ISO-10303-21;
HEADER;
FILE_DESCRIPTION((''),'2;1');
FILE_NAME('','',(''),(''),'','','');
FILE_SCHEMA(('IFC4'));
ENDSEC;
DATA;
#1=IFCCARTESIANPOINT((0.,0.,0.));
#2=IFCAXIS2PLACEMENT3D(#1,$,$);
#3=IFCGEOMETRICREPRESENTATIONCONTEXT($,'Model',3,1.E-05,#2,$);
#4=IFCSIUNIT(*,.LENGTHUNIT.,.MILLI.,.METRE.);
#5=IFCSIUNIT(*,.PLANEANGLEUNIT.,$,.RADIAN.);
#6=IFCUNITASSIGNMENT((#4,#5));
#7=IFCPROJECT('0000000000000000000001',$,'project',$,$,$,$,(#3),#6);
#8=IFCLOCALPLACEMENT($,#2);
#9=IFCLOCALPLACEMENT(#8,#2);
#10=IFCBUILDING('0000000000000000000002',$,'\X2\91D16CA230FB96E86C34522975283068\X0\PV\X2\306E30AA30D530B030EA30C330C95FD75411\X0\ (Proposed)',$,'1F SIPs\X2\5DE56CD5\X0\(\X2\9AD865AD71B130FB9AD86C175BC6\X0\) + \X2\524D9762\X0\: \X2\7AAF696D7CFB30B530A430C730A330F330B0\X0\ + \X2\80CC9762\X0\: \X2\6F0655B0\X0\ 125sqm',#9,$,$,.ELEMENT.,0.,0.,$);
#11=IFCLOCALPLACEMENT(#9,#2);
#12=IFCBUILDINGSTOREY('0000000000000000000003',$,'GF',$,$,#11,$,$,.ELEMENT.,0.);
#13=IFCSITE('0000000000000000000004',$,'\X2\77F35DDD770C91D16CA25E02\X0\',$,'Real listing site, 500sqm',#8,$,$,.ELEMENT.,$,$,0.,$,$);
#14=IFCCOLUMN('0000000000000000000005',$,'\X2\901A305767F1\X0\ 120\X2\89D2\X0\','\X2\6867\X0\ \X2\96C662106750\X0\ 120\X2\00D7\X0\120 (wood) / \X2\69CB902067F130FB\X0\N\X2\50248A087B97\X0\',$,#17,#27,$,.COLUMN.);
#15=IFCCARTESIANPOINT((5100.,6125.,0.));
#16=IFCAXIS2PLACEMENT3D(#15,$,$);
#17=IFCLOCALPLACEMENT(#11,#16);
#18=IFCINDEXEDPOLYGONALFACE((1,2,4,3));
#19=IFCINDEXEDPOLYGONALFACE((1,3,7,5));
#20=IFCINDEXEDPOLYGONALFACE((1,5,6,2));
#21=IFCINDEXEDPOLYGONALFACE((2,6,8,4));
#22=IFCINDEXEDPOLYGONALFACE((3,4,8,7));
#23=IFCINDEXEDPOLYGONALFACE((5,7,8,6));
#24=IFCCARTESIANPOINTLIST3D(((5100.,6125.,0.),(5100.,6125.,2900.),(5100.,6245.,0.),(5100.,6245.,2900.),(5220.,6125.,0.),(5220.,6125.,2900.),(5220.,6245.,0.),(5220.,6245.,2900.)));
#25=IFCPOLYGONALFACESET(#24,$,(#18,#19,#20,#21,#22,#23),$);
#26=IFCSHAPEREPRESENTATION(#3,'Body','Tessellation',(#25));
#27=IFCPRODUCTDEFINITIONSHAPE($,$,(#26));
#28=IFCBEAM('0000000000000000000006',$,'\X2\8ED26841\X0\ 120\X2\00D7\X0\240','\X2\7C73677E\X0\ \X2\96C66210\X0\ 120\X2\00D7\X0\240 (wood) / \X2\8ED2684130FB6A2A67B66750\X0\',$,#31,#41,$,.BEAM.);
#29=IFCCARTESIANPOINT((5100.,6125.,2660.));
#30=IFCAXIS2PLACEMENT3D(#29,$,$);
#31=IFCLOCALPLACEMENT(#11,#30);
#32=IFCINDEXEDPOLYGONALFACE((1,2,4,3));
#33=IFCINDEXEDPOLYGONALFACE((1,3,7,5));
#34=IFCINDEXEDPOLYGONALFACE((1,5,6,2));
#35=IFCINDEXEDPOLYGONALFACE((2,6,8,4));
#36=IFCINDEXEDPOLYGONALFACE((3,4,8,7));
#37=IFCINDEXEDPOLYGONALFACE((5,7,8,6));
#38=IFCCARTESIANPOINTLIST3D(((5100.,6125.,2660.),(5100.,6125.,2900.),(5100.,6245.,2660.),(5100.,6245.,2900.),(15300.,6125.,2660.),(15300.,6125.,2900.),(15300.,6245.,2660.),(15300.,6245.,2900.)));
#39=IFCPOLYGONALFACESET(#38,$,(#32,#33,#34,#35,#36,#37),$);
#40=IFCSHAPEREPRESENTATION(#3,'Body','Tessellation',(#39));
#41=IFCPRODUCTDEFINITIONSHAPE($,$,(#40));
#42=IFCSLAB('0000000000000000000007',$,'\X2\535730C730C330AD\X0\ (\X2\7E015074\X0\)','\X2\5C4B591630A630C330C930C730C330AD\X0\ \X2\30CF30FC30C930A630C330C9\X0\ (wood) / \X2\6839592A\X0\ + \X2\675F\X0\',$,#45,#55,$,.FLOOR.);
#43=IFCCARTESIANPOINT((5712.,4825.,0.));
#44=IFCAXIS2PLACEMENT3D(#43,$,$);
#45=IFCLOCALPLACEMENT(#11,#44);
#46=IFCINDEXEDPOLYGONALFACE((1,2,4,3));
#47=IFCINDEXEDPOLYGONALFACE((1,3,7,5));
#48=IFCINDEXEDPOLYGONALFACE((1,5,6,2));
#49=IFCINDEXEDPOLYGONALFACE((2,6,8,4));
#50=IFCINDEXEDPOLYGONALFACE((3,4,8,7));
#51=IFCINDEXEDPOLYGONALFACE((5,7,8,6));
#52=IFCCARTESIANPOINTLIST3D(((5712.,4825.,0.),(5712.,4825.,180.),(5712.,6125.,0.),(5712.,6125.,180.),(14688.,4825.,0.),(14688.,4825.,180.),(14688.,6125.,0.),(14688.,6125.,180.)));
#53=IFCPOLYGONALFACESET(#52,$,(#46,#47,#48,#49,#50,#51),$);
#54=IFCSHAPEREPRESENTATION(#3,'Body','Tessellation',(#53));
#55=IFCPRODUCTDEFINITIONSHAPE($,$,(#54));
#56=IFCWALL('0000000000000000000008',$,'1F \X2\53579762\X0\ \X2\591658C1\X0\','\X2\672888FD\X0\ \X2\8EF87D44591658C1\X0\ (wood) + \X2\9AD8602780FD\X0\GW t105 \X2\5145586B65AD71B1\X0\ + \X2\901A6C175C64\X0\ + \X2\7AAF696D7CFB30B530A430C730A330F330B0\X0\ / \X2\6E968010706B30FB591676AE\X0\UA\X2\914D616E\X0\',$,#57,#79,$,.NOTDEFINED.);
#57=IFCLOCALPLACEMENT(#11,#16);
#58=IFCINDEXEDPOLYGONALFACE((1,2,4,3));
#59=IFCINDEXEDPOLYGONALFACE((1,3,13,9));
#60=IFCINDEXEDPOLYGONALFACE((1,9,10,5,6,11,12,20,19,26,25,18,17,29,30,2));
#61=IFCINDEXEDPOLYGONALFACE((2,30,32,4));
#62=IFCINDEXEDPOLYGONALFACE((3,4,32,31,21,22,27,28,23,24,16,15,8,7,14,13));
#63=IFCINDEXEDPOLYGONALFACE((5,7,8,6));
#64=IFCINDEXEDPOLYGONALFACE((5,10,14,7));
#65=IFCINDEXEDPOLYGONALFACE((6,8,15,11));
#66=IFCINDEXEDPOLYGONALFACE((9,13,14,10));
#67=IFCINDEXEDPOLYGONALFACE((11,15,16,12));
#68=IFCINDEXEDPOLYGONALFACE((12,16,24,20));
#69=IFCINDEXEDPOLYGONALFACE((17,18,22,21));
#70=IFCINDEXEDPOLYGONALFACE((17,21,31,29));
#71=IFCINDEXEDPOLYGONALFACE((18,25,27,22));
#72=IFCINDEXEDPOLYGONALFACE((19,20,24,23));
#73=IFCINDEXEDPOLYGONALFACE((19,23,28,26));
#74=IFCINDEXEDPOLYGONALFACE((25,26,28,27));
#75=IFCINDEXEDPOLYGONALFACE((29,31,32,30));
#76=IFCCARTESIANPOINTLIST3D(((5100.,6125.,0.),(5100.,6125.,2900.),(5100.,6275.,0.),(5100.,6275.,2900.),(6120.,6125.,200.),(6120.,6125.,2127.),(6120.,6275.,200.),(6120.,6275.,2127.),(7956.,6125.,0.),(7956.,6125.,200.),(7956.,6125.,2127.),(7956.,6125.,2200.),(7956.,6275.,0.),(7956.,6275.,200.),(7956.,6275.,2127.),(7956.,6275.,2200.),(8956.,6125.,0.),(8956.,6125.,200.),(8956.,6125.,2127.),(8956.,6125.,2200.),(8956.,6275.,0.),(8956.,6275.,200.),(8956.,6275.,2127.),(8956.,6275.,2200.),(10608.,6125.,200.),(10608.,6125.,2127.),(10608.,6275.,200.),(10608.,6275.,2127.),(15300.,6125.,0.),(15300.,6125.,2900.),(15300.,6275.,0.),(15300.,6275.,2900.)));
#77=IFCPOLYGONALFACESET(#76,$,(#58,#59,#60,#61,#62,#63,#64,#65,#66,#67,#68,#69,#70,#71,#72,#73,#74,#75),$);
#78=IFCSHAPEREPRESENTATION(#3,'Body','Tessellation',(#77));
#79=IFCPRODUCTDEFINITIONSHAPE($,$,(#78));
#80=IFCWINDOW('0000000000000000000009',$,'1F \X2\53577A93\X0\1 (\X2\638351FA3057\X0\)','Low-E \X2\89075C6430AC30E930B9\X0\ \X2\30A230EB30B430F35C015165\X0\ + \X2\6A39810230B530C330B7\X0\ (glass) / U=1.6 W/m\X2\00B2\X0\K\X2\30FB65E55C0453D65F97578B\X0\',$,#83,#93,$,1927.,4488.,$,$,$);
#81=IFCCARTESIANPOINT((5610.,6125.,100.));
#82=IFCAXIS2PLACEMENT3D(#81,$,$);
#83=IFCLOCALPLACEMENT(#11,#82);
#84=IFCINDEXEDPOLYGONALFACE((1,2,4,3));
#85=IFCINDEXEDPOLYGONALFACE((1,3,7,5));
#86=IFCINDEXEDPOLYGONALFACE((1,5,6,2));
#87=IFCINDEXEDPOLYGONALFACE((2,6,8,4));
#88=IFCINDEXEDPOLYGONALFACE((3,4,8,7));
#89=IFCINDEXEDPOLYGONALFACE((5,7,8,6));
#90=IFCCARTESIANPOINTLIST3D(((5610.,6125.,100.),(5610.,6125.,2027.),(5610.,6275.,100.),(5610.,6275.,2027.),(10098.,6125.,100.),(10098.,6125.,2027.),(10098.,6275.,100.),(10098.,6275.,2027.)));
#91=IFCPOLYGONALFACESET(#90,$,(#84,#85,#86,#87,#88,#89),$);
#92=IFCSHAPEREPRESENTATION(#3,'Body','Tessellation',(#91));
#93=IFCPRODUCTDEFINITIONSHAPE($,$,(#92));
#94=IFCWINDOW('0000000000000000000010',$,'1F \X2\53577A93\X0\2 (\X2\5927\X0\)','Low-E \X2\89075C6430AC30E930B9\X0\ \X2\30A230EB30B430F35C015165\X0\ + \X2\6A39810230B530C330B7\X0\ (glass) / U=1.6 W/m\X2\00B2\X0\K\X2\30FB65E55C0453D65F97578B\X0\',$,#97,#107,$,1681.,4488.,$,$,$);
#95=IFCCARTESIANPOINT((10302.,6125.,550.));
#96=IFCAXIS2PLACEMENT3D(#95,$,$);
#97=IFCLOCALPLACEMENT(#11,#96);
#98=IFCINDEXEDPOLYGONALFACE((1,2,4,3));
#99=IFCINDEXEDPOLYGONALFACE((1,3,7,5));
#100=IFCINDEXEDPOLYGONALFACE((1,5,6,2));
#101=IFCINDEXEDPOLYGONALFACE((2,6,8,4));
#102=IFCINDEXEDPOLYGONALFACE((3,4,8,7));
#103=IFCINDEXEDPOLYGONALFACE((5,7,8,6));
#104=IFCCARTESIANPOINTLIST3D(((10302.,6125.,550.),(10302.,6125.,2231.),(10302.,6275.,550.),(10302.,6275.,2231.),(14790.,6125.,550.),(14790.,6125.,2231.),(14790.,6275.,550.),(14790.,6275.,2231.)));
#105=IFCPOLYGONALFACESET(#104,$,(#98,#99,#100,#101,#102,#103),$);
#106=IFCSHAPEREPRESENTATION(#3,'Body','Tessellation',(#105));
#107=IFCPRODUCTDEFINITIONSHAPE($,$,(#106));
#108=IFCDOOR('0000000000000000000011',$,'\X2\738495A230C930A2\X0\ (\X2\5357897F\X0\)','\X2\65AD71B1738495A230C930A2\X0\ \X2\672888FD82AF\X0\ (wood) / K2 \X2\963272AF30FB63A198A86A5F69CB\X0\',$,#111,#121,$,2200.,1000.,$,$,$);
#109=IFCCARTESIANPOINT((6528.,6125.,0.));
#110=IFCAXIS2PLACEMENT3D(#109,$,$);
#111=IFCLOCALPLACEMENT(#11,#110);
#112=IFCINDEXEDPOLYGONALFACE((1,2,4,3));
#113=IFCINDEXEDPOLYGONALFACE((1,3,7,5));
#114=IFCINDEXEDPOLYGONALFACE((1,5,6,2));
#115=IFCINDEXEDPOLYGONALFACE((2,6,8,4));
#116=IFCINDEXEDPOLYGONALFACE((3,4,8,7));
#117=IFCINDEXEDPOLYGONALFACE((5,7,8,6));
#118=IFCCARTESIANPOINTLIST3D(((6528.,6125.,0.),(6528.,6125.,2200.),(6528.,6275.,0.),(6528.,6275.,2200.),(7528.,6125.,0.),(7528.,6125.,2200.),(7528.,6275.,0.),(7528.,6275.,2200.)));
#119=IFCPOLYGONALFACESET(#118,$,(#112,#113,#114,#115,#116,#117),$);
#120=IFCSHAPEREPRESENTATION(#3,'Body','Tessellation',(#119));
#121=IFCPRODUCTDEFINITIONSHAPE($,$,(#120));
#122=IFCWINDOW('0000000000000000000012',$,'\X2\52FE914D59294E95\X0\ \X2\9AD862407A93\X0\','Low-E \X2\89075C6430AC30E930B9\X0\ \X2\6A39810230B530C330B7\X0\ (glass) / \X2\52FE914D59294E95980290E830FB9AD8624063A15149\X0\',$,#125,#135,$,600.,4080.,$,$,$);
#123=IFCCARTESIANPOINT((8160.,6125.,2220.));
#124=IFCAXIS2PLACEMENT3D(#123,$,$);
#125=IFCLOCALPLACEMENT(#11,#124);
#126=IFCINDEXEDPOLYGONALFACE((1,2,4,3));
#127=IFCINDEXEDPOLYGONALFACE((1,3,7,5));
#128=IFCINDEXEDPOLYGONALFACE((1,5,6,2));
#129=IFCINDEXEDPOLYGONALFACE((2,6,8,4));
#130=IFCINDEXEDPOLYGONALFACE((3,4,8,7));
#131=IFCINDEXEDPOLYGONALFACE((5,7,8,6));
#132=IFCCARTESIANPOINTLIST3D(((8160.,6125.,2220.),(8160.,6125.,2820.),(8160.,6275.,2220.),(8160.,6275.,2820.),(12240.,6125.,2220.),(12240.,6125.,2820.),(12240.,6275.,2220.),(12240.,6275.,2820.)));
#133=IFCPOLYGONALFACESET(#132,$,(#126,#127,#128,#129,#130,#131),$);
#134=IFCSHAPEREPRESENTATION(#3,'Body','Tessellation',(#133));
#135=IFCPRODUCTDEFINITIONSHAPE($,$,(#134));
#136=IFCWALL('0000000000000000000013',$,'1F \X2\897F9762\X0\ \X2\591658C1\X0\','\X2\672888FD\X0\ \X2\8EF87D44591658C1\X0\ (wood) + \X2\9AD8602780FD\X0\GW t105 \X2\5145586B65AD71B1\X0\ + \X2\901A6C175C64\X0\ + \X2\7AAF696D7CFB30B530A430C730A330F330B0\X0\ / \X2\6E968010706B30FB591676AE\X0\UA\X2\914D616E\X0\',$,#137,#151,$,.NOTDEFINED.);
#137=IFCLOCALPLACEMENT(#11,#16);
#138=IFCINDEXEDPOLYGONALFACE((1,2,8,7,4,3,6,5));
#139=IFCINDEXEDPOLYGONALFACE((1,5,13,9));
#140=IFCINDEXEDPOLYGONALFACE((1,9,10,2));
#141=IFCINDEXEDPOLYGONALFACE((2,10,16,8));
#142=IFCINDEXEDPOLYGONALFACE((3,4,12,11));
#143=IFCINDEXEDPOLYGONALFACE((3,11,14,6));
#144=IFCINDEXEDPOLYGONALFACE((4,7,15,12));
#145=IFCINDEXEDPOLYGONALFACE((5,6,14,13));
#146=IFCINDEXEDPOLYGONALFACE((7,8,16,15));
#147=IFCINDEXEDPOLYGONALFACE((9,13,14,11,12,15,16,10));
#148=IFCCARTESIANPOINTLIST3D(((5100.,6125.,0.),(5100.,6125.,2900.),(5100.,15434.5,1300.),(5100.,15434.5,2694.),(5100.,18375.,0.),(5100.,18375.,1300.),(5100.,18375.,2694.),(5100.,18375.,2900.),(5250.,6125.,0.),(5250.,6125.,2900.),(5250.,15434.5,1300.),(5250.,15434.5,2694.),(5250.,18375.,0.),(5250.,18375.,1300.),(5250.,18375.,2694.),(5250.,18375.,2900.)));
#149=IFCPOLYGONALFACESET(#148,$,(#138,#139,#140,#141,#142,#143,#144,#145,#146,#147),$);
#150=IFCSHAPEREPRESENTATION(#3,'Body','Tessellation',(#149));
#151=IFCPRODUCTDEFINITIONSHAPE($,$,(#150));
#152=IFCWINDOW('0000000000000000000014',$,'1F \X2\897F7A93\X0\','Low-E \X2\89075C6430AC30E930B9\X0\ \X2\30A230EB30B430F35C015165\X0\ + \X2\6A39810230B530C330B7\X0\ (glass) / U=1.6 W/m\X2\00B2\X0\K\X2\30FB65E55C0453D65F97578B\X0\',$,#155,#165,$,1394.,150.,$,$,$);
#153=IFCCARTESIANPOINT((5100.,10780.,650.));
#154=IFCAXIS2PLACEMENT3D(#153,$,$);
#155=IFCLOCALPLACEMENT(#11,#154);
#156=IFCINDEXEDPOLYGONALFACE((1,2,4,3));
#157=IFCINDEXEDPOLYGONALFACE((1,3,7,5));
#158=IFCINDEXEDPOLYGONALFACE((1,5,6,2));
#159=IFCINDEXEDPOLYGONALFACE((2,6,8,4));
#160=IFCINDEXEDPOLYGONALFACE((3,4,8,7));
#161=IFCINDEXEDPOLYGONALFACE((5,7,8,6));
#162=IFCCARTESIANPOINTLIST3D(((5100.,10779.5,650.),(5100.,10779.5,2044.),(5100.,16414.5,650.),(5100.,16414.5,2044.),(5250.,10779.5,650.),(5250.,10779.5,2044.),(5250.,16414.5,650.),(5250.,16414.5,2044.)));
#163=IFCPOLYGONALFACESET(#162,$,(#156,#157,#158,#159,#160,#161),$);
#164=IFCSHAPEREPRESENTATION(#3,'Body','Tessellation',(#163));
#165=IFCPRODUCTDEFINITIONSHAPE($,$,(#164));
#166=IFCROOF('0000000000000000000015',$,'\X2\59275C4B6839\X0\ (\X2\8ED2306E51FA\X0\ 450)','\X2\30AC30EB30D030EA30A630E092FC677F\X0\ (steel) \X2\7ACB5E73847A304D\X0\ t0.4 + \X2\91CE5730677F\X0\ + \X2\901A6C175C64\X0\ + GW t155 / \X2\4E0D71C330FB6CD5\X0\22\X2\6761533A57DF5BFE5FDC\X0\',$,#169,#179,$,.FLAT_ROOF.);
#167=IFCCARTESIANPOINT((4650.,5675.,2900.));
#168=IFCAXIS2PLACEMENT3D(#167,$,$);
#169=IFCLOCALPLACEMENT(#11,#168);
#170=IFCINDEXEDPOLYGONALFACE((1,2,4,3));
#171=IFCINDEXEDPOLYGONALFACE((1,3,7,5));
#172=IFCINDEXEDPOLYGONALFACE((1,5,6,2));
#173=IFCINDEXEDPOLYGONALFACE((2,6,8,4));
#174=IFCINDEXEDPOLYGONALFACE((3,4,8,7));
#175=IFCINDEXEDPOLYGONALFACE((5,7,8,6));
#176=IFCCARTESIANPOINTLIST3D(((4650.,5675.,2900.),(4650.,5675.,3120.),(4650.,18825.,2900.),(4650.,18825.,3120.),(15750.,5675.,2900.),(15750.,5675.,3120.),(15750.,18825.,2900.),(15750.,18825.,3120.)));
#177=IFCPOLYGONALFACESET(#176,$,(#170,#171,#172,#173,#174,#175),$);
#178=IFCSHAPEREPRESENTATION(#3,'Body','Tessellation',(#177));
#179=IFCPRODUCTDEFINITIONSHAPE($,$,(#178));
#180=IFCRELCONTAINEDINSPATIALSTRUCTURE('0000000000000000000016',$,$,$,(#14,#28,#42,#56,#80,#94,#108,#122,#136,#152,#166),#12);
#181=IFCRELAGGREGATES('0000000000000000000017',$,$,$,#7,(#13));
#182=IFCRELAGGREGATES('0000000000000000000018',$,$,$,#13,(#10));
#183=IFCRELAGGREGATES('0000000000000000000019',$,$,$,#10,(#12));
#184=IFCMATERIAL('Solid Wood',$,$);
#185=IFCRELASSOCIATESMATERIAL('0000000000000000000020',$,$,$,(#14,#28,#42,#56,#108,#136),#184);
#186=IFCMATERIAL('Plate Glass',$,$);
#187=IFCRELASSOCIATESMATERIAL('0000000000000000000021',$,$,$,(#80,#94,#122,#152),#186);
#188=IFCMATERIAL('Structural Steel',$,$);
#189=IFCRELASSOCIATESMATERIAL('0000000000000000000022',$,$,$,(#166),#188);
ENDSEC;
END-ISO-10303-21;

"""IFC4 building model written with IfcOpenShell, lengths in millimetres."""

from ifc_helpers import new_model, si_unit, frame, frame_2d, origin, place, context, project, spatial, rectangle, extrude, material, element, fill, save


model = new_model("IFC4")

# Units and contexts
model_context = context("Model", 3, precision=1e-05, world=origin())
ifc_project = project(units=[si_unit("LENGTHUNIT", "METRE", prefix="MILLI"), si_unit("PLANEANGLEUNIT", "RADIAN")], contexts=[model_context])

# Site, building, storey
site_placement = place(None, origin())
site = spatial("IfcSite", under=ifc_project, at=site_placement, Name="石川県金沢市", ObjectType="Real listing site, 500sqm", CompositionType="ELEMENT", RefElevation=0.0)
building_placement = place(site_placement, origin())
building = spatial("IfcBuilding", under=site, at=building_placement, Name="金沢・雨水利用とPVのオフグリッド志向 (Proposed)", ObjectType="1F SIPs工法(高断熱・高気密) + 前面: 窯業系サイディング + 背面: 漆喰 125sqm", CompositionType="ELEMENT", ElevationOfRefHeight=0.0, ElevationOfTerrain=0.0)
storey_placement = place(building_placement, origin())
storey = spatial("IfcBuildingStorey", under=building, at=storey_placement, Name="GF", CompositionType="ELEMENT", Elevation=0.0)

# Column
ifc_material_1 = material(Name="Solid Wood")
column_1_placement = place(storey_placement, frame((5100.0, 6125.0, 0.0)))
element("IfcColumn", 1, at=column_1_placement, inside=storey, material=ifc_material_1, Name="通し柱 120角", Description="桧 集成材 120×120 (wood) / 構造柱・N値計算", PredefinedType="COLUMN", context=model_context, shape_type="SweptSolid", body=[
    extrude(rectangle(XDim=120.0, YDim=120.0, at=frame_2d((60.0, 60.0))), frame((5100.0, 6125.0, 0.0)), (0.0, 0.0, 1.0), 2900.0),
])

# Beam
beam_1_placement = place(storey_placement, frame((5100.0, 6125.0, 2660.0)))
element("IfcBeam", 2, at=beam_1_placement, inside=storey, material=ifc_material_1, Name="軒桁 120×240", Description="米松 集成 120×240 (wood) / 軒桁・横架材", PredefinedType="BEAM", context=model_context, shape_type="SweptSolid", body=[
    extrude(rectangle(XDim=10200.0, YDim=120.0, at=frame_2d((5100.0, 60.0))), frame((5100.0, 6125.0, 2660.0)), (0.0, 0.0, 1.0), 240.0),
])

# Slab
slab_1_placement = place(storey_placement, frame((5712.0, 4825.0, 0.0)))
element("IfcSlab", 3, at=slab_1_placement, inside=storey, material=ifc_material_1, Name="南デッキ (縁側)", Description="屋外ウッドデッキ ハードウッド (wood) / 根太 + 束", PredefinedType="FLOOR", context=model_context, shape_type="SweptSolid", body=[
    extrude(rectangle(XDim=8976.0, YDim=1300.0, at=frame_2d((4488.0, 650.0))), frame((5712.0, 4825.0, 0.0)), (0.0, 0.0, 1.0), 180.0),
])

# Wall, openings, windows, door
wall_1_placement = place(storey_placement, frame((5100.0, 6125.0, 0.0)))
wall_1 = element("IfcWall", 4, at=wall_1_placement, inside=storey, material=ifc_material_1, Name="1F 南面 外壁", Description="木製 軸組外壁 (wood) + 高性能GW t105 充填断熱 + 通気層 + 窯業系サイディング / 準耐火・外皮UA配慮", PredefinedType="NOTDEFINED", context=model_context, shape_type="SweptSolid", body=[
    extrude(rectangle(XDim=10200.0, YDim=150.0, at=frame_2d((5100.0, 75.0))), frame((5100.0, 6125.0, 0.0)), (0.0, 0.0, 1.0), 2900.0),
])
opening_1_placement = place(storey_placement, frame((5610.0, 6125.0, 100.0)))
opening_1 = element("IfcOpeningElement", 5, at=opening_1_placement, cuts=wall_1, PredefinedType="NOTDEFINED", context=model_context, shape_type="SweptSolid", body=[
    extrude(rectangle(XDim=4488.0, YDim=150.0, at=frame_2d((2244.0, 75.0))), frame((5610.0, 6125.0, 100.0)), (0.0, 0.0, 1.0), 1927.0),
])
opening_2_placement = place(storey_placement, frame((10302.0, 6125.0, 550.0)))
opening_2 = element("IfcOpeningElement", 6, at=opening_2_placement, cuts=wall_1, PredefinedType="NOTDEFINED", context=model_context, shape_type="SweptSolid", body=[
    extrude(rectangle(XDim=4488.0, YDim=150.0, at=frame_2d((2244.0, 75.0))), frame((10302.0, 6125.0, 550.0)), (0.0, 0.0, 1.0), 1681.0),
])
opening_3_placement = place(storey_placement, frame((6528.0, 6125.0, 0.0)))
opening_3 = element("IfcOpeningElement", 7, at=opening_3_placement, cuts=wall_1, PredefinedType="NOTDEFINED", context=model_context, shape_type="SweptSolid", body=[
    extrude(rectangle(XDim=1000.0, YDim=150.0, at=frame_2d((500.0, 75.0))), frame((6528.0, 6125.0, 0.0)), (0.0, 0.0, 1.0), 2200.0),
])
opening_4_placement = place(storey_placement, frame((8160.0, 6125.0, 2220.0)))
opening_4 = element("IfcOpeningElement", 8, at=opening_4_placement, cuts=wall_1, PredefinedType="NOTDEFINED", context=model_context, shape_type="SweptSolid", body=[
    extrude(rectangle(XDim=4080.0, YDim=150.0, at=frame_2d((2040.0, 75.0))), frame((8160.0, 6125.0, 2220.0)), (0.0, 0.0, 1.0), 600.0),
])
ifc_material_2 = material(Name="Plate Glass")
window_1_placement = place(storey_placement, frame((5610.0, 6125.0, 100.0)))
window_1 = element("IfcWindow", 9, at=window_1_placement, inside=storey, material=ifc_material_2, Name="1F 南窓1 (掃出し)", Description="Low-E 複層ガラス アルゴン封入 + 樹脂サッシ (glass) / U=1.6 W/m²K・日射取得型", OverallHeight=1927.0, OverallWidth=4488.0, context=model_context, shape_type="SweptSolid", body=[
    extrude(rectangle(XDim=4488.0, YDim=150.0, at=frame_2d((2244.0, 75.0))), frame((5610.0, 6125.0, 100.0)), (0.0, 0.0, 1.0), 1927.0),
])
fill(opening_1, window_1)
window_2_placement = place(storey_placement, frame((10302.0, 6125.0, 550.0)))
window_2 = element("IfcWindow", 10, at=window_2_placement, inside=storey, material=ifc_material_2, Name="1F 南窓2 (大)", Description="Low-E 複層ガラス アルゴン封入 + 樹脂サッシ (glass) / U=1.6 W/m²K・日射取得型", OverallHeight=1681.0, OverallWidth=4488.0, context=model_context, shape_type="SweptSolid", body=[
    extrude(rectangle(XDim=4488.0, YDim=150.0, at=frame_2d((2244.0, 75.0))), frame((10302.0, 6125.0, 550.0)), (0.0, 0.0, 1.0), 1681.0),
])
fill(opening_2, window_2)
door_placement = place(storey_placement, frame((6528.0, 6125.0, 0.0)))
door = element("IfcDoor", 11, at=door_placement, inside=storey, material=ifc_material_1, Name="玄関ドア (南西)", Description="断熱玄関ドア 木製芯 (wood) / K2 防犯・採風機構", OverallHeight=2200.0, OverallWidth=1000.0, context=model_context, shape_type="SweptSolid", body=[
    extrude(rectangle(XDim=1000.0, YDim=150.0, at=frame_2d((500.0, 75.0))), frame((6528.0, 6125.0, 0.0)), (0.0, 0.0, 1.0), 2200.0),
])
fill(opening_3, door)
window_3_placement = place(storey_placement, frame((8160.0, 6125.0, 2220.0)))
window_3 = element("IfcWindow", 12, at=window_3_placement, inside=storey, material=ifc_material_2, Name="勾配天井 高所窓", Description="Low-E 複層ガラス 樹脂サッシ (glass) / 勾配天井頂部・高所採光", OverallHeight=600.0, OverallWidth=4080.0, context=model_context, shape_type="SweptSolid", body=[
    extrude(rectangle(XDim=4080.0, YDim=150.0, at=frame_2d((2040.0, 75.0))), frame((8160.0, 6125.0, 2220.0)), (0.0, 0.0, 1.0), 600.0),
])
fill(opening_4, window_3)

# Wall, opening, window
wall_2_placement = place(storey_placement, frame((5100.0, 6125.0, 0.0)))
wall_2 = element("IfcWall", 13, at=wall_2_placement, inside=storey, material=ifc_material_1, Name="1F 西面 外壁", Description="木製 軸組外壁 (wood) + 高性能GW t105 充填断熱 + 通気層 + 窯業系サイディング / 準耐火・外皮UA配慮", PredefinedType="NOTDEFINED", context=model_context, shape_type="SweptSolid", body=[
    extrude(rectangle(XDim=150.0, YDim=12250.0, at=frame_2d((75.0, 6125.0))), frame((5100.0, 6125.0, 0.0)), (0.0, 0.0, 1.0), 2900.0),
])
opening_5_placement = place(storey_placement, frame((5100.0, 10780.0, 650.0)))
opening_5 = element("IfcOpeningElement", 14, at=opening_5_placement, cuts=wall_2, PredefinedType="NOTDEFINED", context=model_context, shape_type="SweptSolid", body=[
    extrude(rectangle(XDim=150.0, YDim=5635.0, at=frame_2d((75.0, 2817.0))), frame((5100.0, 10780.0, 650.0)), (0.0, 0.0, 1.0), 1394.0),
])
window_4_placement = place(storey_placement, frame((5100.0, 10780.0, 650.0)))
window_4 = element("IfcWindow", 15, at=window_4_placement, inside=storey, material=ifc_material_2, Name="1F 西窓", Description="Low-E 複層ガラス アルゴン封入 + 樹脂サッシ (glass) / U=1.6 W/m²K・日射取得型", OverallHeight=1394.0, OverallWidth=150.0, context=model_context, shape_type="SweptSolid", body=[
    extrude(rectangle(XDim=150.0, YDim=5635.0, at=frame_2d((75.0, 2817.0))), frame((5100.0, 10780.0, 650.0)), (0.0, 0.0, 1.0), 1394.0),
])
fill(opening_5, window_4)

# Roof
ifc_material_3 = material(Name="Structural Steel")
roof_placement = place(storey_placement, frame((4650.0, 5675.0, 2900.0)))
element("IfcRoof", 16, at=roof_placement, inside=storey, material=ifc_material_3, Name="大屋根 (軒の出 450)", Description="ガルバリウム鋼板 (steel) 立平葺き t0.4 + 野地板 + 通気層 + GW t155 / 不燃・法22条区域対応", PredefinedType="FLAT_ROOF", context=model_context, shape_type="SweptSolid", body=[
    extrude(rectangle(XDim=11100.0, YDim=13150.0, at=frame_2d((5550.0, 6575.0))), frame((4650.0, 5675.0, 2900.0)), (0.0, 0.0, 1.0), 220.0),
])

save(model, "model.ifc")
